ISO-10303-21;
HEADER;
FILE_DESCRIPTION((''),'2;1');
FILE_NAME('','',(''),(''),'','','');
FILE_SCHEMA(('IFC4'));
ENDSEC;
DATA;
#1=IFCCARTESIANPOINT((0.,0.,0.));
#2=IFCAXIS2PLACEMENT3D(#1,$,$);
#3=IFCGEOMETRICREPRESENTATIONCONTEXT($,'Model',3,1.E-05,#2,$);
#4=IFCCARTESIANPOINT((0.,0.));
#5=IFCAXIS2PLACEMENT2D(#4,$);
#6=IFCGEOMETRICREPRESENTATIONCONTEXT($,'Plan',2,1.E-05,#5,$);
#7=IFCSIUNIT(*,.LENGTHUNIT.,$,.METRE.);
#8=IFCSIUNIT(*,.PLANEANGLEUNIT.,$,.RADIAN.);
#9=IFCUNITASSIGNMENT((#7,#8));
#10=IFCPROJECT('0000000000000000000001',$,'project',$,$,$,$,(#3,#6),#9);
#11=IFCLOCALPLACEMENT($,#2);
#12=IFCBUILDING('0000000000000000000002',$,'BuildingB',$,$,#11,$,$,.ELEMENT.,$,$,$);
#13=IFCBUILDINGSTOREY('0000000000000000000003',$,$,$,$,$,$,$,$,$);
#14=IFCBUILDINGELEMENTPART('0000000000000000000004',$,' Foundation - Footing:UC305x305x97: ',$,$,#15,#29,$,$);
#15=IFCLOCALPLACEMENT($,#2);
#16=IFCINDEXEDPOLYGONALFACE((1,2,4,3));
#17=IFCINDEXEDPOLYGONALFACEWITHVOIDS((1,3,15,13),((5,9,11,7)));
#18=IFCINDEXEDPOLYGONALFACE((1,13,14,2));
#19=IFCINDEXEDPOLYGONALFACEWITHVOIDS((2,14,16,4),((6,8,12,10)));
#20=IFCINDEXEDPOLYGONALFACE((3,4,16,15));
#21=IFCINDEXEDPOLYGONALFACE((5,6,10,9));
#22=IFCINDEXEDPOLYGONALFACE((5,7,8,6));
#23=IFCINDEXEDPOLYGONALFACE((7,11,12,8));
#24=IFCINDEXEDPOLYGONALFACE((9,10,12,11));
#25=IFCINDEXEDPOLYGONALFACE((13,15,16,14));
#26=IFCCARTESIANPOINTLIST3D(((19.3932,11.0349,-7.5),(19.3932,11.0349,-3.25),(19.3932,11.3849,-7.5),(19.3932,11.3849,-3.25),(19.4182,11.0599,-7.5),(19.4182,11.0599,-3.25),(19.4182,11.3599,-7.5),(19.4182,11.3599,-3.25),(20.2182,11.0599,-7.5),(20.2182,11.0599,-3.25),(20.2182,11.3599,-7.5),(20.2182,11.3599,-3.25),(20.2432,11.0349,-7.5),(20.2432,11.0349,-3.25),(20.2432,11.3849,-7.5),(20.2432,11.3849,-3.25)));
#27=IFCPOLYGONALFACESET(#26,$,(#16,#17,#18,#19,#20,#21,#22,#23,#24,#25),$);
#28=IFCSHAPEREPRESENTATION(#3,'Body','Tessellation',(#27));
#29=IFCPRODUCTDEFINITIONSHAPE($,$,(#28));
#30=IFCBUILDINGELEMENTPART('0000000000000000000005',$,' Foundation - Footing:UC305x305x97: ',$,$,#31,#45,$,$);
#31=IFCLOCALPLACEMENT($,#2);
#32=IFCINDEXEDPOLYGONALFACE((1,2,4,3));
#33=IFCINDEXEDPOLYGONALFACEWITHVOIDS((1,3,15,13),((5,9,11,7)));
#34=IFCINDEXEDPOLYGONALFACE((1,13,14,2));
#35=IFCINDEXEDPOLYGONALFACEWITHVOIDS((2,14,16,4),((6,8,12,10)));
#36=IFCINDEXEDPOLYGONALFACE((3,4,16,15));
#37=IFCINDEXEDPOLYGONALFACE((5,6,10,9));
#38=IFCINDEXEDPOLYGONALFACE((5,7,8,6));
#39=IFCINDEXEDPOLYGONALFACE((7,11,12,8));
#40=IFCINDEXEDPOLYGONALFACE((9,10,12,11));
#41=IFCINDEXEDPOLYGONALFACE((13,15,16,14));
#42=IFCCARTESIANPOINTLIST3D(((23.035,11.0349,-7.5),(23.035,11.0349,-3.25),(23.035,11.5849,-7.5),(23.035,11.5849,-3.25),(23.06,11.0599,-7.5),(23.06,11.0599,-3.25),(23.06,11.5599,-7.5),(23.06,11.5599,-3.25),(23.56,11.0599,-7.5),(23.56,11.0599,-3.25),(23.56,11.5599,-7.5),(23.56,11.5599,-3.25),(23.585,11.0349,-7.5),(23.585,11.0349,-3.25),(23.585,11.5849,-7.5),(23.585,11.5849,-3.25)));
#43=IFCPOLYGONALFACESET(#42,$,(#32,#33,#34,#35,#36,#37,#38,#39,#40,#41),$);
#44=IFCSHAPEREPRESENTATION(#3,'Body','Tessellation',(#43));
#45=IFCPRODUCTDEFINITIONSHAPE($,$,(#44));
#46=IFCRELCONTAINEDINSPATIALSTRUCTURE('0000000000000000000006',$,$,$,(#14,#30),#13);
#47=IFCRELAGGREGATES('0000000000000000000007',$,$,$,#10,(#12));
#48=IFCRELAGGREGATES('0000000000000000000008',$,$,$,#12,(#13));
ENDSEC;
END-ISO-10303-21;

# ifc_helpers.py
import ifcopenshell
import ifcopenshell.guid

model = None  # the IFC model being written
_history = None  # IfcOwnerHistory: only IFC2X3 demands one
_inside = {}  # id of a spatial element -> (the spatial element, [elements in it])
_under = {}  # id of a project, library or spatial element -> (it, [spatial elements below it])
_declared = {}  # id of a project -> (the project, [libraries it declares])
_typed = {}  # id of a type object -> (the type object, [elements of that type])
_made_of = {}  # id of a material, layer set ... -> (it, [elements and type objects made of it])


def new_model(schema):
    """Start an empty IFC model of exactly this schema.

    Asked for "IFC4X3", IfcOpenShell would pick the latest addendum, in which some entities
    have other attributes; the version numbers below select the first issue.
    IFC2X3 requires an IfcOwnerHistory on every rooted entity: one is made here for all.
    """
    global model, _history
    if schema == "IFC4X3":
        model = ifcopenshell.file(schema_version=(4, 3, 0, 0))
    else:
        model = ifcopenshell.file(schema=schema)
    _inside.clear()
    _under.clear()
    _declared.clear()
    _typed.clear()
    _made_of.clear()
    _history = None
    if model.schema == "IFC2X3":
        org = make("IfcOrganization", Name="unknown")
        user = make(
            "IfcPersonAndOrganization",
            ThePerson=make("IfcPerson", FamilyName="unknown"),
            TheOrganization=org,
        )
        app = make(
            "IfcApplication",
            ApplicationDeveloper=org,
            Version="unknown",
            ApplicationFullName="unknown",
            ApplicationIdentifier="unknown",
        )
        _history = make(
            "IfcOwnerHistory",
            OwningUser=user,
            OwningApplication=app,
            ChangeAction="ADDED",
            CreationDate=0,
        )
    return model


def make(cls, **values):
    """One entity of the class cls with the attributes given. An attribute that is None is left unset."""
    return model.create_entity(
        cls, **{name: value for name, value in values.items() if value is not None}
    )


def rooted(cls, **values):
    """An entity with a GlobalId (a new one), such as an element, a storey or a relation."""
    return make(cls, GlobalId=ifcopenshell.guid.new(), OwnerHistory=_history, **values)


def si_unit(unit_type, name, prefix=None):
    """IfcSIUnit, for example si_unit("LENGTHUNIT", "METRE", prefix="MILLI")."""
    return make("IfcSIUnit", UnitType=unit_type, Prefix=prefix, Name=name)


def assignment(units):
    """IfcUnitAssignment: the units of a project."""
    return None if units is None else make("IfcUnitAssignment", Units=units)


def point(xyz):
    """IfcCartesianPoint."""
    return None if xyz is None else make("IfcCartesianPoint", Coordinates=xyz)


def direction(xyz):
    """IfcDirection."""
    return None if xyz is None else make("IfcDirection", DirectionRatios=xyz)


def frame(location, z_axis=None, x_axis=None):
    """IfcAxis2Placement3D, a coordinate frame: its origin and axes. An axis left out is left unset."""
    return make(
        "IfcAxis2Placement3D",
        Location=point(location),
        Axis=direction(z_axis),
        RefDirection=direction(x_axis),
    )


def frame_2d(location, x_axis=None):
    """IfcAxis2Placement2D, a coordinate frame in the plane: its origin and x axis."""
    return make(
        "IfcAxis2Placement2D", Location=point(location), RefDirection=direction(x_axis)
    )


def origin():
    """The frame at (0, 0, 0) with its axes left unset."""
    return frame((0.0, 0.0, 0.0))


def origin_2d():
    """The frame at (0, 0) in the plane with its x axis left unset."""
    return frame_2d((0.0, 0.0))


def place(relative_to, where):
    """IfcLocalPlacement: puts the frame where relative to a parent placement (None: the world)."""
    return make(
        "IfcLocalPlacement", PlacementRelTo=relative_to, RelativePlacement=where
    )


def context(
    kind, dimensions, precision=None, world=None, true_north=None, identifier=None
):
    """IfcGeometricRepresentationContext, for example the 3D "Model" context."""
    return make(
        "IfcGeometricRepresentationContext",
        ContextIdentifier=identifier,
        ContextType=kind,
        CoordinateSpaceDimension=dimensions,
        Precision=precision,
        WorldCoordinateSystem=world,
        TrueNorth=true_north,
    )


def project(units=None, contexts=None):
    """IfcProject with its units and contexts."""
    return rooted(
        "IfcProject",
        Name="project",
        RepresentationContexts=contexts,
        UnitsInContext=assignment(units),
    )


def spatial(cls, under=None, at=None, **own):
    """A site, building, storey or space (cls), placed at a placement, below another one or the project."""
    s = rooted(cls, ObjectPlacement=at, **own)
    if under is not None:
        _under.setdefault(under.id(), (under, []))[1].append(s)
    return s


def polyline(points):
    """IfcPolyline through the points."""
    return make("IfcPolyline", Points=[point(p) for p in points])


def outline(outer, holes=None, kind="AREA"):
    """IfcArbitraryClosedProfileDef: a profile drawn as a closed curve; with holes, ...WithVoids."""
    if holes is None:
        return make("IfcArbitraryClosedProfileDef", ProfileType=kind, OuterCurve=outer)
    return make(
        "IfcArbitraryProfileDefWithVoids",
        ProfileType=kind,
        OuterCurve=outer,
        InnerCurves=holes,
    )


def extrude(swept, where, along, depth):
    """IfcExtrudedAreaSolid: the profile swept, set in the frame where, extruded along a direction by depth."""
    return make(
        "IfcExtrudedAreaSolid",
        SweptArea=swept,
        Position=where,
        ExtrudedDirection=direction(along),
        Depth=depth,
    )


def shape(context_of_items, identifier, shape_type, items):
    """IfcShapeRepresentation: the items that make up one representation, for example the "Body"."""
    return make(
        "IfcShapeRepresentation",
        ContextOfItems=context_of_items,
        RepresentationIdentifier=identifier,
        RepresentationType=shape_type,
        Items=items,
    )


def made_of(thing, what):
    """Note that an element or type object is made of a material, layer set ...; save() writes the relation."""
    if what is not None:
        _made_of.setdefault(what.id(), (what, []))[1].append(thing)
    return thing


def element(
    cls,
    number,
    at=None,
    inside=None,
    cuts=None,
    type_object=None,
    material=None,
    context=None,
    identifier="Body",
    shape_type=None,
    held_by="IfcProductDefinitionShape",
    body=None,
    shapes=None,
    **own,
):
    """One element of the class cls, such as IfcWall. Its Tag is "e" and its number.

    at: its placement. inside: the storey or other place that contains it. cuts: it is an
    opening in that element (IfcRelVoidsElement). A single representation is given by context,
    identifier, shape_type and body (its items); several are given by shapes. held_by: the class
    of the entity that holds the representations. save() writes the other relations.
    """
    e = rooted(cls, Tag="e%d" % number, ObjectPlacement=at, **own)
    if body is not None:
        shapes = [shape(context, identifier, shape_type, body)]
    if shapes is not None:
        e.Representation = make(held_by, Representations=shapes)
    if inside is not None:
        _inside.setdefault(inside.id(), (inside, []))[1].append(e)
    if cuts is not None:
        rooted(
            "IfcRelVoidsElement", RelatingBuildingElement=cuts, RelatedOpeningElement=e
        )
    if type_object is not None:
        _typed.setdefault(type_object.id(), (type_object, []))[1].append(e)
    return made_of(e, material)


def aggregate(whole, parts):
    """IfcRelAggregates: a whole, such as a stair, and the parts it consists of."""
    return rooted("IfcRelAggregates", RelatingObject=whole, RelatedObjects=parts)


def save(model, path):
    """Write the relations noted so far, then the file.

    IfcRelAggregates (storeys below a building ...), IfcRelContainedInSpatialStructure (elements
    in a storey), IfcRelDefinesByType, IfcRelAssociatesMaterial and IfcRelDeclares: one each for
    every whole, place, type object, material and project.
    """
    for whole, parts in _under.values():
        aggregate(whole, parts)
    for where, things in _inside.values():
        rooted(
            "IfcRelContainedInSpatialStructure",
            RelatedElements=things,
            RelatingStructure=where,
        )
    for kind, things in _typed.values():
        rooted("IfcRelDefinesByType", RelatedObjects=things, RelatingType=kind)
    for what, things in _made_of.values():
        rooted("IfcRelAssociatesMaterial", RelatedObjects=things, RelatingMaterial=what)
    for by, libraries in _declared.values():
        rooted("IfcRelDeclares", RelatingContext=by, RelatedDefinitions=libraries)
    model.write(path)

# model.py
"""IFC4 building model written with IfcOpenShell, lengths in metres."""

from ifc_helpers import new_model, si_unit, origin, origin_2d, place, context, project, spatial, polyline, outline, extrude, element, save


model = new_model("IFC4")

# Units and contexts
model_context = context("Model", 3, precision=1e-05, world=origin())
plan_context = context("Plan", 2, precision=1e-05, world=origin_2d())
ifc_project = project(units=[si_unit("LENGTHUNIT", "METRE"), si_unit("PLANEANGLEUNIT", "RADIAN")], contexts=[model_context, plan_context])

# Building, storey
building_placement = place(None, origin())
building = spatial("IfcBuilding", under=ifc_project, at=building_placement, Name="BuildingB", CompositionType="ELEMENT")
storey = spatial("IfcBuildingStorey", under=building)

# Building element parts, openings
building_element_part_1 = element("IfcBuildingElementPart", 1, inside=storey, Name=" Foundation - Footing:UC305x305x97: ", context=model_context, shape_type="SweptSolid", body=[
    extrude(outline(polyline([(19.3932, 11.0349, -7.5), (20.2432, 11.0349, -7.5), (20.2432, 11.3849, -7.5), (19.3932, 11.3849, -7.5), (19.3932, 11.0349, -7.5)])), None, (0.0, 0.0, 1.0), 4.25),
])
element("IfcOpeningElement", 2, inside=storey, cuts=building_element_part_1, context=model_context, shape_type="SweptSolid", body=[
    extrude(outline(polyline([(19.4182, 11.0599, -7.5), (20.2182, 11.0599, -7.5), (20.2182, 11.3599, -7.5), (19.4182, 11.3599, -7.5), (19.4182, 11.0599, -7.5)])), None, (0.0, 0.0, 1.0), 4.25),
])
building_element_part_2 = element("IfcBuildingElementPart", 3, inside=storey, Name=" Foundation - Footing:UC305x305x97: ", context=model_context, shape_type="SweptSolid", body=[
    extrude(outline(polyline([(23.035, 11.0349, -7.5), (23.585, 11.0349, -7.5), (23.585, 11.5849, -7.5), (23.035, 11.5849, -7.5), (23.035, 11.0349, -7.5)])), None, (0.0, 0.0, 1.0), 4.25),
])
element("IfcOpeningElement", 4, inside=storey, cuts=building_element_part_2, context=model_context, shape_type="SweptSolid", body=[
    extrude(outline(polyline([(23.06, 11.0599, -7.5), (23.56, 11.0599, -7.5), (23.56, 11.5599, -7.5), (23.06, 11.5599, -7.5), (23.06, 11.0599, -7.5)])), None, (0.0, 0.0, 1.0), 4.25),
])

save(model, "model.ifc")
